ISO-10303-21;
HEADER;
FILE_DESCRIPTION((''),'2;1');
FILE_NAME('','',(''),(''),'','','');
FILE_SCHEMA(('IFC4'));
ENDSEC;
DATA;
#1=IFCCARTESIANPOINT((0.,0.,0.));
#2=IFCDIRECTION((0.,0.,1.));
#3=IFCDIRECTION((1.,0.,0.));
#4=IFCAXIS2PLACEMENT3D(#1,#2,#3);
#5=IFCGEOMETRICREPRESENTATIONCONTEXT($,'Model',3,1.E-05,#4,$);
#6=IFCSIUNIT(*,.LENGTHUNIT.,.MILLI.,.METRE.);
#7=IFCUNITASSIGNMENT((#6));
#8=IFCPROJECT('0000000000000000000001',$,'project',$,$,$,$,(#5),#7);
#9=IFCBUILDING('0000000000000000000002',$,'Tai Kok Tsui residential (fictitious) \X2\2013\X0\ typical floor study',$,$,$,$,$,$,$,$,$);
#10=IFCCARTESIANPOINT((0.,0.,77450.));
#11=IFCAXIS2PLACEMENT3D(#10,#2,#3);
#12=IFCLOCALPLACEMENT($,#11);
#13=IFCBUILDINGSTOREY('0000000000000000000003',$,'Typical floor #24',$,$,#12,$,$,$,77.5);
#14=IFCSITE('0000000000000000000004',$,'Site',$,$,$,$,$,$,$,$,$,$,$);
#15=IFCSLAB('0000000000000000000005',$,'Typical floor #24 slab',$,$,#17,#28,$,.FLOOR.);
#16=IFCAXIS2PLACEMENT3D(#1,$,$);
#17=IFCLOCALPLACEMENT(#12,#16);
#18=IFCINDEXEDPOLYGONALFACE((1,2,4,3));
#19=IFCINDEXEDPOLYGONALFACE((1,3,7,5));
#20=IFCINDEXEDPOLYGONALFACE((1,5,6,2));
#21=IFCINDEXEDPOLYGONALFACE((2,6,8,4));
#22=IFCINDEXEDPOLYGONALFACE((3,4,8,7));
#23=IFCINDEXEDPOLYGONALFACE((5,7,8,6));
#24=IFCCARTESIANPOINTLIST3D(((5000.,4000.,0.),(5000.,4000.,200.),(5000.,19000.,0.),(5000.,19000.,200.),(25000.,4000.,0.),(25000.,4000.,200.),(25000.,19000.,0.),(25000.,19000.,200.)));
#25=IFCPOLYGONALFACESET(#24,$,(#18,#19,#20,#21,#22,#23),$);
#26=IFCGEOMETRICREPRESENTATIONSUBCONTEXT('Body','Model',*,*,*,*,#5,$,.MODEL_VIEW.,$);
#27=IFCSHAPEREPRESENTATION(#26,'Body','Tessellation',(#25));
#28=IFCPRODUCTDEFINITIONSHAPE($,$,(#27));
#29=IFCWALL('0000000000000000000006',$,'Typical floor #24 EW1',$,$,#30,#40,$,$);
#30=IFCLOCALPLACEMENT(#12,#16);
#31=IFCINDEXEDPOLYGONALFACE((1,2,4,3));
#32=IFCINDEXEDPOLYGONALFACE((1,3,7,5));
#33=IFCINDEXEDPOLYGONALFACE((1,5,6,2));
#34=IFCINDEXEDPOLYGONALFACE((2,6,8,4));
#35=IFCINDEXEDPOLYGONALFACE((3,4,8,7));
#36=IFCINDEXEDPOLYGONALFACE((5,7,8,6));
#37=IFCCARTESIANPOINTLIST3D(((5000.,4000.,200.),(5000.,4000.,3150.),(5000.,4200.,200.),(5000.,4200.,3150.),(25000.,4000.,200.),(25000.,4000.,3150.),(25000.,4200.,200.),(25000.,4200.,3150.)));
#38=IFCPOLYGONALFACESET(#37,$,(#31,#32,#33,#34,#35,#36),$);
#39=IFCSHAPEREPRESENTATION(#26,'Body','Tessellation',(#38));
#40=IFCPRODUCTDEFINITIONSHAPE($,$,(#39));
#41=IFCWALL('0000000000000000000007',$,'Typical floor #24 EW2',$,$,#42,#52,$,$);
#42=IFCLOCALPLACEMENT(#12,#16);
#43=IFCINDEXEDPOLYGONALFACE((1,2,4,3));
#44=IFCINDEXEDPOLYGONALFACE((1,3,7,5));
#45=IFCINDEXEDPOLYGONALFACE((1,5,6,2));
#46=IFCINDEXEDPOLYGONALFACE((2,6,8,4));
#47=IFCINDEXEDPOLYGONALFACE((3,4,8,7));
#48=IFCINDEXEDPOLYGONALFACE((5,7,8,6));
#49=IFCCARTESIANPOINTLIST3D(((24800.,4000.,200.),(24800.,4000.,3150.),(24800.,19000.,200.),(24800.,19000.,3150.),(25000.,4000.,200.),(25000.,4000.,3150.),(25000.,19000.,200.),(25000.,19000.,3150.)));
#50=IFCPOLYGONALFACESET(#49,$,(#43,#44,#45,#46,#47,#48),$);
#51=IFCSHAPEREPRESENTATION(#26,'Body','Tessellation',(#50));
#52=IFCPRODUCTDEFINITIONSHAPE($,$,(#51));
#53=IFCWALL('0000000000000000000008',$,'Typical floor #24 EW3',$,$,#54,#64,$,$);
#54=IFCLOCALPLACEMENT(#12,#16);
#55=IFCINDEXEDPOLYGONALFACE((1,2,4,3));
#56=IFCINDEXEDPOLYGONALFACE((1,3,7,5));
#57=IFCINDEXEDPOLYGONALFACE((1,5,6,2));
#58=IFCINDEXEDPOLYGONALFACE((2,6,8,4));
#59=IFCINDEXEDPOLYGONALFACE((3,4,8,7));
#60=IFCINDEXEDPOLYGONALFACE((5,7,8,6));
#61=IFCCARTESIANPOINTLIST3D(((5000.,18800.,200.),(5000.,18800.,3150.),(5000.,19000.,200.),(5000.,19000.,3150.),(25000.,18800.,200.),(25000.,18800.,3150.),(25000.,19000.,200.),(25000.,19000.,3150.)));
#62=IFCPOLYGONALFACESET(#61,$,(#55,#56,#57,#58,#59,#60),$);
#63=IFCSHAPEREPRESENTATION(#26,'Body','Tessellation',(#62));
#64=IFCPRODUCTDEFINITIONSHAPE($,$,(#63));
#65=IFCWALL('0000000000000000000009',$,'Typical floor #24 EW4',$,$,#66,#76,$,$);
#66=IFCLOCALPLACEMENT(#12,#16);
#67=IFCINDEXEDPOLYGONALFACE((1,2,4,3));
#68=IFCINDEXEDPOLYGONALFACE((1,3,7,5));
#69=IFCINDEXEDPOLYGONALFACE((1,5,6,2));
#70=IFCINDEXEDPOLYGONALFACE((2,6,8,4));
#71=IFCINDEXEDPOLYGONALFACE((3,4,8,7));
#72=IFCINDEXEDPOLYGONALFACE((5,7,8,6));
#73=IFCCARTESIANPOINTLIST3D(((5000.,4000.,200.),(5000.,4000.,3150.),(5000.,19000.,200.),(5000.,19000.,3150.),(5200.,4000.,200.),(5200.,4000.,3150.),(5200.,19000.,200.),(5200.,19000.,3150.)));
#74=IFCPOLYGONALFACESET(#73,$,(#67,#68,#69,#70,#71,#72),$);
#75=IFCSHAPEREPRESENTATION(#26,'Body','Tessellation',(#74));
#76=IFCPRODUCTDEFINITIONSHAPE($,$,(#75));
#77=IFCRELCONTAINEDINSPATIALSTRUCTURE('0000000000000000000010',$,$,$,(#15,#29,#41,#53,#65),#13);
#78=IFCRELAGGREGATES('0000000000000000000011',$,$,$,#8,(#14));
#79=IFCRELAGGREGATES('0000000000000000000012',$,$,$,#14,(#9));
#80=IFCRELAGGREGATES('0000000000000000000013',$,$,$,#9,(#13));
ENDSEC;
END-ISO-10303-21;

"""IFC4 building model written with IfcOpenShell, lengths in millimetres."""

from ifc_helpers import new_model, si_unit, frame, origin_with_axes, place, context, subcontext, project, spatial, indexed_curve, outline, extrude, element, save


model = new_model("IFC4")

# Units and contexts
model_context = context("Model", 3, precision=1e-05, world=origin_with_axes())
body_context = subcontext(model_context, "Body", "Model", "MODEL_VIEW")
ifc_project = project(units=[si_unit("LENGTHUNIT", "METRE", prefix="MILLI")], contexts=[model_context])

# Site, building, storey
site = spatial("IfcSite", under=ifc_project, Name="Site")
building = spatial("IfcBuilding", under=site, Name="Tai Kok Tsui residential (fictitious) – typical floor study")
storey_placement = place(None, frame((0.0, 0.0, 77450.0), z_axis=(0.0, 0.0, 1.0), x_axis=(1.0, 0.0, 0.0)))
storey = spatial("IfcBuildingStorey", under=building, at=storey_placement, Name="Typical floor #24", Elevation=77.5)

# Slab
slab_placement = place(storey_placement, origin_with_axes())
element("IfcSlab", 1, at=slab_placement, inside=storey, Name="Typical floor #24 slab", PredefinedType="FLOOR", context=body_context, shape_type="SweptSolid", body=[
    extrude(outline(indexed_curve([(5000.0, 4000.0), (25000.0, 4000.0), (25000.0, 19000.0), (5000.0, 19000.0)])), None, (0.0, 0.0, 1.0), 200.0),
])

# Walls
wall_1_placement = place(storey_placement, frame((5000.0, 4000.0, 200.0), z_axis=(0.0, 0.0, 1.0), x_axis=(1.0, 0.0, 0.0)))
element("IfcWall", 2, at=wall_1_placement, inside=storey, Name="Typical floor #24 EW1", context=body_context, shape_type="SweptSolid", body=[
    extrude(outline(indexed_curve([(0.0, 0.0), (0.0, 200.0), (20000.0, 200.0), (20000.0, 0.0), (0.0, 0.0)], self_intersect=False)), origin_with_axes(), (0.0, 0.0, 1.0), 2950.0),
])
wall_2_placement = place(storey_placement, frame((25000.0, 4000.0, 200.0), z_axis=(0.0, 0.0, 1.0), x_axis=(0.0, 1.0, 0.0)))
element("IfcWall", 3, at=wall_2_placement, inside=storey, Name="Typical floor #24 EW2", context=body_context, shape_type="SweptSolid", body=[
    extrude(outline(indexed_curve([(0.0, 0.0), (0.0, 200.0), (15000.0, 200.0), (15000.0, 0.0), (0.0, 0.0)], self_intersect=False)), origin_with_axes(), (0.0, 0.0, 1.0), 2950.0),
])
wall_3_placement = place(storey_placement, frame((25000.0, 19000.0, 200.0), z_axis=(0.0, 0.0, 1.0), x_axis=(-1.0, 0.0, 0.0)))
element("IfcWall", 4, at=wall_3_placement, inside=storey, Name="Typical floor #24 EW3", context=body_context, shape_type="SweptSolid", body=[
    extrude(outline(indexed_curve([(0.0, 0.0), (0.0, 200.0), (20000.0, 200.0), (20000.0, 0.0), (0.0, 0.0)], self_intersect=False)), origin_with_axes(), (0.0, 0.0, 1.0), 2950.0),
])
wall_4_placement = place(storey_placement, frame((5000.0, 19000.0, 200.0), z_axis=(0.0, 0.0, 1.0), x_axis=(0.0, -1.0, 0.0)))
element("IfcWall", 5, at=wall_4_placement, inside=storey, Name="Typical floor #24 EW4", context=body_context, shape_type="SweptSolid", body=[
    extrude(outline(indexed_curve([(0.0, 0.0), (0.0, 200.0), (15000.0, 200.0), (15000.0, 0.0), (0.0, 0.0)], self_intersect=False)), origin_with_axes(), (0.0, 0.0, 1.0), 2950.0),
])

save(model, "model.ifc")
